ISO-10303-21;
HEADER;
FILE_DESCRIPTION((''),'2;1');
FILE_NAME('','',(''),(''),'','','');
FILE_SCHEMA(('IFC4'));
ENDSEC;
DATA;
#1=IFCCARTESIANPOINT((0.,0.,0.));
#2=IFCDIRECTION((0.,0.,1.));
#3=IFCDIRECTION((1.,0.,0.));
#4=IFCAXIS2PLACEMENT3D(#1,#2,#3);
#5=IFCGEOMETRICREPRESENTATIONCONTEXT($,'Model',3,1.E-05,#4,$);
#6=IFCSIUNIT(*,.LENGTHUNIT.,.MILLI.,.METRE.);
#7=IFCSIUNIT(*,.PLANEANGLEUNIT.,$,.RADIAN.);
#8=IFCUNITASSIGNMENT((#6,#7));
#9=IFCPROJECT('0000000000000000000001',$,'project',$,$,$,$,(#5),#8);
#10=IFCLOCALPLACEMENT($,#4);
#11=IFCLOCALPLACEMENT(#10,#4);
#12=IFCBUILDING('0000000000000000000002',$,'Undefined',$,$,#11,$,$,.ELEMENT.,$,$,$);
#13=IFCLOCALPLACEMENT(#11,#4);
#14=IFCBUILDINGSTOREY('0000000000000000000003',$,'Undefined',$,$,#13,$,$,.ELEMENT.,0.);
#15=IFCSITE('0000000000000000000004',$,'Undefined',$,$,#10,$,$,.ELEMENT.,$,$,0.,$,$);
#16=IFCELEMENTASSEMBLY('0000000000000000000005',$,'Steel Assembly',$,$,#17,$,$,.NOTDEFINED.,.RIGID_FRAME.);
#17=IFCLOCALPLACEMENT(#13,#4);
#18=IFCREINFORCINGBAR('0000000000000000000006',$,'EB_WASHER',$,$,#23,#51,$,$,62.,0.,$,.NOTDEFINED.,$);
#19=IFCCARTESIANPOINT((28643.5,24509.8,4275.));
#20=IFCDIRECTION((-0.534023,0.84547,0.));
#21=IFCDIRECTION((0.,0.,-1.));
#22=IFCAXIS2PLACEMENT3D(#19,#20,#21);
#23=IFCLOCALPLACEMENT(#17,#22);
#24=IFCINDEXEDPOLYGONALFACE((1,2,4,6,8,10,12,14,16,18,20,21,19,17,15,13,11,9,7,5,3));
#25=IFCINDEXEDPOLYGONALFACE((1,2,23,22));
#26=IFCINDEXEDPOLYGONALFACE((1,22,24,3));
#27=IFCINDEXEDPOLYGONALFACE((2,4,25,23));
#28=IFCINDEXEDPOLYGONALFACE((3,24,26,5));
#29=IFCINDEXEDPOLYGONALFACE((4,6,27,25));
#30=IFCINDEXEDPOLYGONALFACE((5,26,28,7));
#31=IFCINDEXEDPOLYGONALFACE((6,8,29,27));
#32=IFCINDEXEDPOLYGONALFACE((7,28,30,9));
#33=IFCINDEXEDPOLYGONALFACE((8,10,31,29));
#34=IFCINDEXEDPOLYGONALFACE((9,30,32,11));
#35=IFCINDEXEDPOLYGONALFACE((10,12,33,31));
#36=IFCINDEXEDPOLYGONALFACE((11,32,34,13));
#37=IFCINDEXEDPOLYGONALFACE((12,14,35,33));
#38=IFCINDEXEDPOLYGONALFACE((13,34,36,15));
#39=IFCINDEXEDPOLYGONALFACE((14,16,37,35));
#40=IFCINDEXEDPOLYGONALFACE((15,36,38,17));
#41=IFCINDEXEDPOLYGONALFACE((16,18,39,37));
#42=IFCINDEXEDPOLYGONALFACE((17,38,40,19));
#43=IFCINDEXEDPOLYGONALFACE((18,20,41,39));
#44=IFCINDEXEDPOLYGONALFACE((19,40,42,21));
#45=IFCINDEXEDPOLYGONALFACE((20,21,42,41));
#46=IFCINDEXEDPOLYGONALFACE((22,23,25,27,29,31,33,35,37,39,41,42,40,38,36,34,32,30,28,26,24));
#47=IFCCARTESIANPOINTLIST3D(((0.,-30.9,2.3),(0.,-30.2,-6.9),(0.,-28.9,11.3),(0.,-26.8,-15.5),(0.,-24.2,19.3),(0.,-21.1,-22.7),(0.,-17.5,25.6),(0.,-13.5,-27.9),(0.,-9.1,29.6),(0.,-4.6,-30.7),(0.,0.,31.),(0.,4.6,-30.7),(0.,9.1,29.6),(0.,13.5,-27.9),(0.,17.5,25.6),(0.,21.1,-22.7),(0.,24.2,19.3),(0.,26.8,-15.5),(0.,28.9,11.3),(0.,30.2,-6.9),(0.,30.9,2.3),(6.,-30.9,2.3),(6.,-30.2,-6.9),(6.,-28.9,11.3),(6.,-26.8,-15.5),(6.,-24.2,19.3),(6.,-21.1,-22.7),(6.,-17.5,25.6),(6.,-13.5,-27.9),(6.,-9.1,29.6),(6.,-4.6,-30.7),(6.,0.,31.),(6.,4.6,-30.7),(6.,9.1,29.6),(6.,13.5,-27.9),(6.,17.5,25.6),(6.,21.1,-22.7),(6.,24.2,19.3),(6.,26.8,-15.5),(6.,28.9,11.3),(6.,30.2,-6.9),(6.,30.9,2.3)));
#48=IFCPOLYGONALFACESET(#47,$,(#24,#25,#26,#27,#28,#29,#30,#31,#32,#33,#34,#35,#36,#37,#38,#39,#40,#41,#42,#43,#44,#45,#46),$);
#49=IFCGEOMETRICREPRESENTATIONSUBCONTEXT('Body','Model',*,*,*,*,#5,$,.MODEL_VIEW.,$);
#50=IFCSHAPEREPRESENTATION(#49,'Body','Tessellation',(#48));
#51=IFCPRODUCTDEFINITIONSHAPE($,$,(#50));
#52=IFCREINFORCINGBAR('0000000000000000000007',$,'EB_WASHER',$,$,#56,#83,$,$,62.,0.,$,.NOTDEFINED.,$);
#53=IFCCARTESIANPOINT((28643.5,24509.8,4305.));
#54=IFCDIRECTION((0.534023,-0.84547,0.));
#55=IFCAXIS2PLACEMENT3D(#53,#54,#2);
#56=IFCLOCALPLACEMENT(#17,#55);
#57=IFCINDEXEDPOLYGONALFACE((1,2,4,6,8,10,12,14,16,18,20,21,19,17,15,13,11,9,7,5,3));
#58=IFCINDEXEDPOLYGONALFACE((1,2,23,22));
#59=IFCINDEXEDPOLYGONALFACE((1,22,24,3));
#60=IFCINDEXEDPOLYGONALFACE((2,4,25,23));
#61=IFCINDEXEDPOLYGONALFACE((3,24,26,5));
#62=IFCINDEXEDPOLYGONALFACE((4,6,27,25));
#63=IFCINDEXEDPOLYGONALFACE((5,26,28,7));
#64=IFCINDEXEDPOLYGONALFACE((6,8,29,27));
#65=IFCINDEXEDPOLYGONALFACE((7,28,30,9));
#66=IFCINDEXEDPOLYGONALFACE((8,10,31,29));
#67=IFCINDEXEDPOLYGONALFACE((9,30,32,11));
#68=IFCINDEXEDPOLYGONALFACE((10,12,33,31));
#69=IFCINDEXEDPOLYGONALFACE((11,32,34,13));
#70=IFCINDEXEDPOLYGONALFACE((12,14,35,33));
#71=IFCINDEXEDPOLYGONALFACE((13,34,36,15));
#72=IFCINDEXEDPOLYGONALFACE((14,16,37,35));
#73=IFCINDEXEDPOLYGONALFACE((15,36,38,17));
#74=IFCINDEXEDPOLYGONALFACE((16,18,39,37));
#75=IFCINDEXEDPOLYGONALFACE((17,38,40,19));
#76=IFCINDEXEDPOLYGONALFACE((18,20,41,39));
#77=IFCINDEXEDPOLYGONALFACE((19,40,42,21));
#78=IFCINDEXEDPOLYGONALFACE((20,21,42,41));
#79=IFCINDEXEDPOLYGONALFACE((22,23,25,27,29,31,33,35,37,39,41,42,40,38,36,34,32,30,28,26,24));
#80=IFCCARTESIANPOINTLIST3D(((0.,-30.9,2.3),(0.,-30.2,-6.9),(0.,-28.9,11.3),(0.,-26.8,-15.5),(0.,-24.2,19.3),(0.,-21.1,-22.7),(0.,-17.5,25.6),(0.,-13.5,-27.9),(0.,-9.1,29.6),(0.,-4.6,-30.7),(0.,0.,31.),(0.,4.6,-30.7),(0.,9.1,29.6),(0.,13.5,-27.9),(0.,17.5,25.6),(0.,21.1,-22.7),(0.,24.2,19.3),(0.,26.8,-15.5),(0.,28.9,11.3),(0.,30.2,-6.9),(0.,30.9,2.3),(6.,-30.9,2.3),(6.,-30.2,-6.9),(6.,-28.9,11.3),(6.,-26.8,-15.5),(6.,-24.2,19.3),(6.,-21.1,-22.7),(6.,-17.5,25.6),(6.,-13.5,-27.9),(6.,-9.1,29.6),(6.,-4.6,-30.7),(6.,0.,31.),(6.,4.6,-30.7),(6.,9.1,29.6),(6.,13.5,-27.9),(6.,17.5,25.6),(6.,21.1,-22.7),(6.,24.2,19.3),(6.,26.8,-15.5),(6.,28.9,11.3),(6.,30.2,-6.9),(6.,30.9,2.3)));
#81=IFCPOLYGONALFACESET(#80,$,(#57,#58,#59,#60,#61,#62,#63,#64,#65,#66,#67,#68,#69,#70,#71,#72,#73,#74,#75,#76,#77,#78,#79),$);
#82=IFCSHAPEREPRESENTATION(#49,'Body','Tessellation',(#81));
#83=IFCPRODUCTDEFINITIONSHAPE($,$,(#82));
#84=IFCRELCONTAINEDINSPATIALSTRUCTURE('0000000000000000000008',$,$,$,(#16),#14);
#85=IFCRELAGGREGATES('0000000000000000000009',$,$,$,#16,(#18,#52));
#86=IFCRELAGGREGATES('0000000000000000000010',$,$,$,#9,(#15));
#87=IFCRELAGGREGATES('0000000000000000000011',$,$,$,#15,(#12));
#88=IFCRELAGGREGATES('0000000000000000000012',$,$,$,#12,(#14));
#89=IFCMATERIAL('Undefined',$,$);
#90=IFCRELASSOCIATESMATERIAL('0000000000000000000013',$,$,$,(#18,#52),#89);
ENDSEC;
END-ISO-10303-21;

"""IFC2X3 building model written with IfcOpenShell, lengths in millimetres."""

from ifc_helpers import new_model, entity, si_unit, frame, origin_with_axes, place, context, subcontext, project, spatial, source, transform, mapped, material, element, aggregate, save


model = new_model("IFC2X3")

# Units and contexts
model_context = context("Model", 3, precision=1e-05, world=origin_with_axes())
body_context = subcontext(model_context, "Body", "Model", "MODEL_VIEW")
ifc_project = project(units=[si_unit("LENGTHUNIT", "METRE", prefix="MILLI"), si_unit("PLANEANGLEUNIT", "RADIAN")], contexts=[model_context])

# Site, building, storey
site_placement = place(None, origin_with_axes())
site = spatial("IfcSite", under=ifc_project, at=site_placement, Name="Undefined", CompositionType="ELEMENT", RefElevation=0.0)
building_placement = place(site_placement, origin_with_axes())
building = spatial("IfcBuilding", under=site, at=building_placement, Name="Undefined", CompositionType="ELEMENT")
storey_placement = place(building_placement, origin_with_axes())
storey = spatial("IfcBuildingStorey", under=building, at=storey_placement, Name="Undefined", CompositionType="ELEMENT", Elevation=0.0)

# Element assembly
assembly_1_placement = place(storey_placement, origin_with_axes())
assembly_1 = element("IfcElementAssembly", 1, at=assembly_1_placement, inside=storey, Name="Steel Assembly", AssemblyPlace="NOTDEFINED", PredefinedType="RIGID_FRAME")

# Shared definitions
ifc_material_1 = material(Name="Undefined")

# Reinforcing bars
shared_shape_1 = source(origin_with_axes(), body_context, "Body", "AdvancedSweptSolid", [
    entity("IfcSweptDiskSolid", entity("IfcTrimmedCurve", entity("IfcLine", entity("IfcCartesianPoint", [0.0, 0.0, 0.0]), entity("IfcVector", entity("IfcDirection", [1.0, 0.0, 0.0]), 1.0)), [entity("IfcParameterValue", 0.0)], [entity("IfcParameterValue", 6.0)], True, "PARAMETER"), 31.0, None, 0.0, 6.0),
])
reinforcing_bar_1_placement = place(assembly_1_placement, frame((28643.5, 24509.8, 4275.0), z_axis=(-0.534023, 0.84547, 0.0), x_axis=(0.0, 0.0, -1.0)))
reinforcing_bar_1 = element("IfcReinforcingBar", 2, at=reinforcing_bar_1_placement, material=ifc_material_1, Name="EB_WASHER", BarRole="NOTDEFINED", CrossSectionArea=0.0, NominalDiameter=62.0, context=body_context, shape_type="MappedRepresentation", body=[
    mapped(shared_shape_1, transform((0.0, 0.0, 0.0))),
])
shared_shape_2 = source(origin_with_axes(), body_context, "Body", "AdvancedSweptSolid", [
    entity("IfcSweptDiskSolid", entity("IfcTrimmedCurve", entity("IfcLine", entity("IfcCartesianPoint", [0.0, 0.0, 0.0]), entity("IfcVector", entity("IfcDirection", [1.0, 0.0, 0.0]), 1.0)), [entity("IfcParameterValue", 0.0)], [entity("IfcParameterValue", 6.0)], True, "PARAMETER"), 31.0, None, 0.0, 6.0),
])
reinforcing_bar_2_placement = place(assembly_1_placement, frame((28643.5, 24509.8, 4305.0), z_axis=(0.534023, -0.84547, 0.0), x_axis=(0.0, 0.0, 1.0)))
reinforcing_bar_2 = element("IfcReinforcingBar", 3, at=reinforcing_bar_2_placement, material=ifc_material_1, Name="EB_WASHER", BarRole="NOTDEFINED", CrossSectionArea=0.0, NominalDiameter=62.0, context=body_context, shape_type="MappedRepresentation", body=[
    mapped(shared_shape_2, transform((0.0, 0.0, 0.0))),
])
aggregate(assembly_1, [reinforcing_bar_1, reinforcing_bar_2])

save(model, "model.ifc")
